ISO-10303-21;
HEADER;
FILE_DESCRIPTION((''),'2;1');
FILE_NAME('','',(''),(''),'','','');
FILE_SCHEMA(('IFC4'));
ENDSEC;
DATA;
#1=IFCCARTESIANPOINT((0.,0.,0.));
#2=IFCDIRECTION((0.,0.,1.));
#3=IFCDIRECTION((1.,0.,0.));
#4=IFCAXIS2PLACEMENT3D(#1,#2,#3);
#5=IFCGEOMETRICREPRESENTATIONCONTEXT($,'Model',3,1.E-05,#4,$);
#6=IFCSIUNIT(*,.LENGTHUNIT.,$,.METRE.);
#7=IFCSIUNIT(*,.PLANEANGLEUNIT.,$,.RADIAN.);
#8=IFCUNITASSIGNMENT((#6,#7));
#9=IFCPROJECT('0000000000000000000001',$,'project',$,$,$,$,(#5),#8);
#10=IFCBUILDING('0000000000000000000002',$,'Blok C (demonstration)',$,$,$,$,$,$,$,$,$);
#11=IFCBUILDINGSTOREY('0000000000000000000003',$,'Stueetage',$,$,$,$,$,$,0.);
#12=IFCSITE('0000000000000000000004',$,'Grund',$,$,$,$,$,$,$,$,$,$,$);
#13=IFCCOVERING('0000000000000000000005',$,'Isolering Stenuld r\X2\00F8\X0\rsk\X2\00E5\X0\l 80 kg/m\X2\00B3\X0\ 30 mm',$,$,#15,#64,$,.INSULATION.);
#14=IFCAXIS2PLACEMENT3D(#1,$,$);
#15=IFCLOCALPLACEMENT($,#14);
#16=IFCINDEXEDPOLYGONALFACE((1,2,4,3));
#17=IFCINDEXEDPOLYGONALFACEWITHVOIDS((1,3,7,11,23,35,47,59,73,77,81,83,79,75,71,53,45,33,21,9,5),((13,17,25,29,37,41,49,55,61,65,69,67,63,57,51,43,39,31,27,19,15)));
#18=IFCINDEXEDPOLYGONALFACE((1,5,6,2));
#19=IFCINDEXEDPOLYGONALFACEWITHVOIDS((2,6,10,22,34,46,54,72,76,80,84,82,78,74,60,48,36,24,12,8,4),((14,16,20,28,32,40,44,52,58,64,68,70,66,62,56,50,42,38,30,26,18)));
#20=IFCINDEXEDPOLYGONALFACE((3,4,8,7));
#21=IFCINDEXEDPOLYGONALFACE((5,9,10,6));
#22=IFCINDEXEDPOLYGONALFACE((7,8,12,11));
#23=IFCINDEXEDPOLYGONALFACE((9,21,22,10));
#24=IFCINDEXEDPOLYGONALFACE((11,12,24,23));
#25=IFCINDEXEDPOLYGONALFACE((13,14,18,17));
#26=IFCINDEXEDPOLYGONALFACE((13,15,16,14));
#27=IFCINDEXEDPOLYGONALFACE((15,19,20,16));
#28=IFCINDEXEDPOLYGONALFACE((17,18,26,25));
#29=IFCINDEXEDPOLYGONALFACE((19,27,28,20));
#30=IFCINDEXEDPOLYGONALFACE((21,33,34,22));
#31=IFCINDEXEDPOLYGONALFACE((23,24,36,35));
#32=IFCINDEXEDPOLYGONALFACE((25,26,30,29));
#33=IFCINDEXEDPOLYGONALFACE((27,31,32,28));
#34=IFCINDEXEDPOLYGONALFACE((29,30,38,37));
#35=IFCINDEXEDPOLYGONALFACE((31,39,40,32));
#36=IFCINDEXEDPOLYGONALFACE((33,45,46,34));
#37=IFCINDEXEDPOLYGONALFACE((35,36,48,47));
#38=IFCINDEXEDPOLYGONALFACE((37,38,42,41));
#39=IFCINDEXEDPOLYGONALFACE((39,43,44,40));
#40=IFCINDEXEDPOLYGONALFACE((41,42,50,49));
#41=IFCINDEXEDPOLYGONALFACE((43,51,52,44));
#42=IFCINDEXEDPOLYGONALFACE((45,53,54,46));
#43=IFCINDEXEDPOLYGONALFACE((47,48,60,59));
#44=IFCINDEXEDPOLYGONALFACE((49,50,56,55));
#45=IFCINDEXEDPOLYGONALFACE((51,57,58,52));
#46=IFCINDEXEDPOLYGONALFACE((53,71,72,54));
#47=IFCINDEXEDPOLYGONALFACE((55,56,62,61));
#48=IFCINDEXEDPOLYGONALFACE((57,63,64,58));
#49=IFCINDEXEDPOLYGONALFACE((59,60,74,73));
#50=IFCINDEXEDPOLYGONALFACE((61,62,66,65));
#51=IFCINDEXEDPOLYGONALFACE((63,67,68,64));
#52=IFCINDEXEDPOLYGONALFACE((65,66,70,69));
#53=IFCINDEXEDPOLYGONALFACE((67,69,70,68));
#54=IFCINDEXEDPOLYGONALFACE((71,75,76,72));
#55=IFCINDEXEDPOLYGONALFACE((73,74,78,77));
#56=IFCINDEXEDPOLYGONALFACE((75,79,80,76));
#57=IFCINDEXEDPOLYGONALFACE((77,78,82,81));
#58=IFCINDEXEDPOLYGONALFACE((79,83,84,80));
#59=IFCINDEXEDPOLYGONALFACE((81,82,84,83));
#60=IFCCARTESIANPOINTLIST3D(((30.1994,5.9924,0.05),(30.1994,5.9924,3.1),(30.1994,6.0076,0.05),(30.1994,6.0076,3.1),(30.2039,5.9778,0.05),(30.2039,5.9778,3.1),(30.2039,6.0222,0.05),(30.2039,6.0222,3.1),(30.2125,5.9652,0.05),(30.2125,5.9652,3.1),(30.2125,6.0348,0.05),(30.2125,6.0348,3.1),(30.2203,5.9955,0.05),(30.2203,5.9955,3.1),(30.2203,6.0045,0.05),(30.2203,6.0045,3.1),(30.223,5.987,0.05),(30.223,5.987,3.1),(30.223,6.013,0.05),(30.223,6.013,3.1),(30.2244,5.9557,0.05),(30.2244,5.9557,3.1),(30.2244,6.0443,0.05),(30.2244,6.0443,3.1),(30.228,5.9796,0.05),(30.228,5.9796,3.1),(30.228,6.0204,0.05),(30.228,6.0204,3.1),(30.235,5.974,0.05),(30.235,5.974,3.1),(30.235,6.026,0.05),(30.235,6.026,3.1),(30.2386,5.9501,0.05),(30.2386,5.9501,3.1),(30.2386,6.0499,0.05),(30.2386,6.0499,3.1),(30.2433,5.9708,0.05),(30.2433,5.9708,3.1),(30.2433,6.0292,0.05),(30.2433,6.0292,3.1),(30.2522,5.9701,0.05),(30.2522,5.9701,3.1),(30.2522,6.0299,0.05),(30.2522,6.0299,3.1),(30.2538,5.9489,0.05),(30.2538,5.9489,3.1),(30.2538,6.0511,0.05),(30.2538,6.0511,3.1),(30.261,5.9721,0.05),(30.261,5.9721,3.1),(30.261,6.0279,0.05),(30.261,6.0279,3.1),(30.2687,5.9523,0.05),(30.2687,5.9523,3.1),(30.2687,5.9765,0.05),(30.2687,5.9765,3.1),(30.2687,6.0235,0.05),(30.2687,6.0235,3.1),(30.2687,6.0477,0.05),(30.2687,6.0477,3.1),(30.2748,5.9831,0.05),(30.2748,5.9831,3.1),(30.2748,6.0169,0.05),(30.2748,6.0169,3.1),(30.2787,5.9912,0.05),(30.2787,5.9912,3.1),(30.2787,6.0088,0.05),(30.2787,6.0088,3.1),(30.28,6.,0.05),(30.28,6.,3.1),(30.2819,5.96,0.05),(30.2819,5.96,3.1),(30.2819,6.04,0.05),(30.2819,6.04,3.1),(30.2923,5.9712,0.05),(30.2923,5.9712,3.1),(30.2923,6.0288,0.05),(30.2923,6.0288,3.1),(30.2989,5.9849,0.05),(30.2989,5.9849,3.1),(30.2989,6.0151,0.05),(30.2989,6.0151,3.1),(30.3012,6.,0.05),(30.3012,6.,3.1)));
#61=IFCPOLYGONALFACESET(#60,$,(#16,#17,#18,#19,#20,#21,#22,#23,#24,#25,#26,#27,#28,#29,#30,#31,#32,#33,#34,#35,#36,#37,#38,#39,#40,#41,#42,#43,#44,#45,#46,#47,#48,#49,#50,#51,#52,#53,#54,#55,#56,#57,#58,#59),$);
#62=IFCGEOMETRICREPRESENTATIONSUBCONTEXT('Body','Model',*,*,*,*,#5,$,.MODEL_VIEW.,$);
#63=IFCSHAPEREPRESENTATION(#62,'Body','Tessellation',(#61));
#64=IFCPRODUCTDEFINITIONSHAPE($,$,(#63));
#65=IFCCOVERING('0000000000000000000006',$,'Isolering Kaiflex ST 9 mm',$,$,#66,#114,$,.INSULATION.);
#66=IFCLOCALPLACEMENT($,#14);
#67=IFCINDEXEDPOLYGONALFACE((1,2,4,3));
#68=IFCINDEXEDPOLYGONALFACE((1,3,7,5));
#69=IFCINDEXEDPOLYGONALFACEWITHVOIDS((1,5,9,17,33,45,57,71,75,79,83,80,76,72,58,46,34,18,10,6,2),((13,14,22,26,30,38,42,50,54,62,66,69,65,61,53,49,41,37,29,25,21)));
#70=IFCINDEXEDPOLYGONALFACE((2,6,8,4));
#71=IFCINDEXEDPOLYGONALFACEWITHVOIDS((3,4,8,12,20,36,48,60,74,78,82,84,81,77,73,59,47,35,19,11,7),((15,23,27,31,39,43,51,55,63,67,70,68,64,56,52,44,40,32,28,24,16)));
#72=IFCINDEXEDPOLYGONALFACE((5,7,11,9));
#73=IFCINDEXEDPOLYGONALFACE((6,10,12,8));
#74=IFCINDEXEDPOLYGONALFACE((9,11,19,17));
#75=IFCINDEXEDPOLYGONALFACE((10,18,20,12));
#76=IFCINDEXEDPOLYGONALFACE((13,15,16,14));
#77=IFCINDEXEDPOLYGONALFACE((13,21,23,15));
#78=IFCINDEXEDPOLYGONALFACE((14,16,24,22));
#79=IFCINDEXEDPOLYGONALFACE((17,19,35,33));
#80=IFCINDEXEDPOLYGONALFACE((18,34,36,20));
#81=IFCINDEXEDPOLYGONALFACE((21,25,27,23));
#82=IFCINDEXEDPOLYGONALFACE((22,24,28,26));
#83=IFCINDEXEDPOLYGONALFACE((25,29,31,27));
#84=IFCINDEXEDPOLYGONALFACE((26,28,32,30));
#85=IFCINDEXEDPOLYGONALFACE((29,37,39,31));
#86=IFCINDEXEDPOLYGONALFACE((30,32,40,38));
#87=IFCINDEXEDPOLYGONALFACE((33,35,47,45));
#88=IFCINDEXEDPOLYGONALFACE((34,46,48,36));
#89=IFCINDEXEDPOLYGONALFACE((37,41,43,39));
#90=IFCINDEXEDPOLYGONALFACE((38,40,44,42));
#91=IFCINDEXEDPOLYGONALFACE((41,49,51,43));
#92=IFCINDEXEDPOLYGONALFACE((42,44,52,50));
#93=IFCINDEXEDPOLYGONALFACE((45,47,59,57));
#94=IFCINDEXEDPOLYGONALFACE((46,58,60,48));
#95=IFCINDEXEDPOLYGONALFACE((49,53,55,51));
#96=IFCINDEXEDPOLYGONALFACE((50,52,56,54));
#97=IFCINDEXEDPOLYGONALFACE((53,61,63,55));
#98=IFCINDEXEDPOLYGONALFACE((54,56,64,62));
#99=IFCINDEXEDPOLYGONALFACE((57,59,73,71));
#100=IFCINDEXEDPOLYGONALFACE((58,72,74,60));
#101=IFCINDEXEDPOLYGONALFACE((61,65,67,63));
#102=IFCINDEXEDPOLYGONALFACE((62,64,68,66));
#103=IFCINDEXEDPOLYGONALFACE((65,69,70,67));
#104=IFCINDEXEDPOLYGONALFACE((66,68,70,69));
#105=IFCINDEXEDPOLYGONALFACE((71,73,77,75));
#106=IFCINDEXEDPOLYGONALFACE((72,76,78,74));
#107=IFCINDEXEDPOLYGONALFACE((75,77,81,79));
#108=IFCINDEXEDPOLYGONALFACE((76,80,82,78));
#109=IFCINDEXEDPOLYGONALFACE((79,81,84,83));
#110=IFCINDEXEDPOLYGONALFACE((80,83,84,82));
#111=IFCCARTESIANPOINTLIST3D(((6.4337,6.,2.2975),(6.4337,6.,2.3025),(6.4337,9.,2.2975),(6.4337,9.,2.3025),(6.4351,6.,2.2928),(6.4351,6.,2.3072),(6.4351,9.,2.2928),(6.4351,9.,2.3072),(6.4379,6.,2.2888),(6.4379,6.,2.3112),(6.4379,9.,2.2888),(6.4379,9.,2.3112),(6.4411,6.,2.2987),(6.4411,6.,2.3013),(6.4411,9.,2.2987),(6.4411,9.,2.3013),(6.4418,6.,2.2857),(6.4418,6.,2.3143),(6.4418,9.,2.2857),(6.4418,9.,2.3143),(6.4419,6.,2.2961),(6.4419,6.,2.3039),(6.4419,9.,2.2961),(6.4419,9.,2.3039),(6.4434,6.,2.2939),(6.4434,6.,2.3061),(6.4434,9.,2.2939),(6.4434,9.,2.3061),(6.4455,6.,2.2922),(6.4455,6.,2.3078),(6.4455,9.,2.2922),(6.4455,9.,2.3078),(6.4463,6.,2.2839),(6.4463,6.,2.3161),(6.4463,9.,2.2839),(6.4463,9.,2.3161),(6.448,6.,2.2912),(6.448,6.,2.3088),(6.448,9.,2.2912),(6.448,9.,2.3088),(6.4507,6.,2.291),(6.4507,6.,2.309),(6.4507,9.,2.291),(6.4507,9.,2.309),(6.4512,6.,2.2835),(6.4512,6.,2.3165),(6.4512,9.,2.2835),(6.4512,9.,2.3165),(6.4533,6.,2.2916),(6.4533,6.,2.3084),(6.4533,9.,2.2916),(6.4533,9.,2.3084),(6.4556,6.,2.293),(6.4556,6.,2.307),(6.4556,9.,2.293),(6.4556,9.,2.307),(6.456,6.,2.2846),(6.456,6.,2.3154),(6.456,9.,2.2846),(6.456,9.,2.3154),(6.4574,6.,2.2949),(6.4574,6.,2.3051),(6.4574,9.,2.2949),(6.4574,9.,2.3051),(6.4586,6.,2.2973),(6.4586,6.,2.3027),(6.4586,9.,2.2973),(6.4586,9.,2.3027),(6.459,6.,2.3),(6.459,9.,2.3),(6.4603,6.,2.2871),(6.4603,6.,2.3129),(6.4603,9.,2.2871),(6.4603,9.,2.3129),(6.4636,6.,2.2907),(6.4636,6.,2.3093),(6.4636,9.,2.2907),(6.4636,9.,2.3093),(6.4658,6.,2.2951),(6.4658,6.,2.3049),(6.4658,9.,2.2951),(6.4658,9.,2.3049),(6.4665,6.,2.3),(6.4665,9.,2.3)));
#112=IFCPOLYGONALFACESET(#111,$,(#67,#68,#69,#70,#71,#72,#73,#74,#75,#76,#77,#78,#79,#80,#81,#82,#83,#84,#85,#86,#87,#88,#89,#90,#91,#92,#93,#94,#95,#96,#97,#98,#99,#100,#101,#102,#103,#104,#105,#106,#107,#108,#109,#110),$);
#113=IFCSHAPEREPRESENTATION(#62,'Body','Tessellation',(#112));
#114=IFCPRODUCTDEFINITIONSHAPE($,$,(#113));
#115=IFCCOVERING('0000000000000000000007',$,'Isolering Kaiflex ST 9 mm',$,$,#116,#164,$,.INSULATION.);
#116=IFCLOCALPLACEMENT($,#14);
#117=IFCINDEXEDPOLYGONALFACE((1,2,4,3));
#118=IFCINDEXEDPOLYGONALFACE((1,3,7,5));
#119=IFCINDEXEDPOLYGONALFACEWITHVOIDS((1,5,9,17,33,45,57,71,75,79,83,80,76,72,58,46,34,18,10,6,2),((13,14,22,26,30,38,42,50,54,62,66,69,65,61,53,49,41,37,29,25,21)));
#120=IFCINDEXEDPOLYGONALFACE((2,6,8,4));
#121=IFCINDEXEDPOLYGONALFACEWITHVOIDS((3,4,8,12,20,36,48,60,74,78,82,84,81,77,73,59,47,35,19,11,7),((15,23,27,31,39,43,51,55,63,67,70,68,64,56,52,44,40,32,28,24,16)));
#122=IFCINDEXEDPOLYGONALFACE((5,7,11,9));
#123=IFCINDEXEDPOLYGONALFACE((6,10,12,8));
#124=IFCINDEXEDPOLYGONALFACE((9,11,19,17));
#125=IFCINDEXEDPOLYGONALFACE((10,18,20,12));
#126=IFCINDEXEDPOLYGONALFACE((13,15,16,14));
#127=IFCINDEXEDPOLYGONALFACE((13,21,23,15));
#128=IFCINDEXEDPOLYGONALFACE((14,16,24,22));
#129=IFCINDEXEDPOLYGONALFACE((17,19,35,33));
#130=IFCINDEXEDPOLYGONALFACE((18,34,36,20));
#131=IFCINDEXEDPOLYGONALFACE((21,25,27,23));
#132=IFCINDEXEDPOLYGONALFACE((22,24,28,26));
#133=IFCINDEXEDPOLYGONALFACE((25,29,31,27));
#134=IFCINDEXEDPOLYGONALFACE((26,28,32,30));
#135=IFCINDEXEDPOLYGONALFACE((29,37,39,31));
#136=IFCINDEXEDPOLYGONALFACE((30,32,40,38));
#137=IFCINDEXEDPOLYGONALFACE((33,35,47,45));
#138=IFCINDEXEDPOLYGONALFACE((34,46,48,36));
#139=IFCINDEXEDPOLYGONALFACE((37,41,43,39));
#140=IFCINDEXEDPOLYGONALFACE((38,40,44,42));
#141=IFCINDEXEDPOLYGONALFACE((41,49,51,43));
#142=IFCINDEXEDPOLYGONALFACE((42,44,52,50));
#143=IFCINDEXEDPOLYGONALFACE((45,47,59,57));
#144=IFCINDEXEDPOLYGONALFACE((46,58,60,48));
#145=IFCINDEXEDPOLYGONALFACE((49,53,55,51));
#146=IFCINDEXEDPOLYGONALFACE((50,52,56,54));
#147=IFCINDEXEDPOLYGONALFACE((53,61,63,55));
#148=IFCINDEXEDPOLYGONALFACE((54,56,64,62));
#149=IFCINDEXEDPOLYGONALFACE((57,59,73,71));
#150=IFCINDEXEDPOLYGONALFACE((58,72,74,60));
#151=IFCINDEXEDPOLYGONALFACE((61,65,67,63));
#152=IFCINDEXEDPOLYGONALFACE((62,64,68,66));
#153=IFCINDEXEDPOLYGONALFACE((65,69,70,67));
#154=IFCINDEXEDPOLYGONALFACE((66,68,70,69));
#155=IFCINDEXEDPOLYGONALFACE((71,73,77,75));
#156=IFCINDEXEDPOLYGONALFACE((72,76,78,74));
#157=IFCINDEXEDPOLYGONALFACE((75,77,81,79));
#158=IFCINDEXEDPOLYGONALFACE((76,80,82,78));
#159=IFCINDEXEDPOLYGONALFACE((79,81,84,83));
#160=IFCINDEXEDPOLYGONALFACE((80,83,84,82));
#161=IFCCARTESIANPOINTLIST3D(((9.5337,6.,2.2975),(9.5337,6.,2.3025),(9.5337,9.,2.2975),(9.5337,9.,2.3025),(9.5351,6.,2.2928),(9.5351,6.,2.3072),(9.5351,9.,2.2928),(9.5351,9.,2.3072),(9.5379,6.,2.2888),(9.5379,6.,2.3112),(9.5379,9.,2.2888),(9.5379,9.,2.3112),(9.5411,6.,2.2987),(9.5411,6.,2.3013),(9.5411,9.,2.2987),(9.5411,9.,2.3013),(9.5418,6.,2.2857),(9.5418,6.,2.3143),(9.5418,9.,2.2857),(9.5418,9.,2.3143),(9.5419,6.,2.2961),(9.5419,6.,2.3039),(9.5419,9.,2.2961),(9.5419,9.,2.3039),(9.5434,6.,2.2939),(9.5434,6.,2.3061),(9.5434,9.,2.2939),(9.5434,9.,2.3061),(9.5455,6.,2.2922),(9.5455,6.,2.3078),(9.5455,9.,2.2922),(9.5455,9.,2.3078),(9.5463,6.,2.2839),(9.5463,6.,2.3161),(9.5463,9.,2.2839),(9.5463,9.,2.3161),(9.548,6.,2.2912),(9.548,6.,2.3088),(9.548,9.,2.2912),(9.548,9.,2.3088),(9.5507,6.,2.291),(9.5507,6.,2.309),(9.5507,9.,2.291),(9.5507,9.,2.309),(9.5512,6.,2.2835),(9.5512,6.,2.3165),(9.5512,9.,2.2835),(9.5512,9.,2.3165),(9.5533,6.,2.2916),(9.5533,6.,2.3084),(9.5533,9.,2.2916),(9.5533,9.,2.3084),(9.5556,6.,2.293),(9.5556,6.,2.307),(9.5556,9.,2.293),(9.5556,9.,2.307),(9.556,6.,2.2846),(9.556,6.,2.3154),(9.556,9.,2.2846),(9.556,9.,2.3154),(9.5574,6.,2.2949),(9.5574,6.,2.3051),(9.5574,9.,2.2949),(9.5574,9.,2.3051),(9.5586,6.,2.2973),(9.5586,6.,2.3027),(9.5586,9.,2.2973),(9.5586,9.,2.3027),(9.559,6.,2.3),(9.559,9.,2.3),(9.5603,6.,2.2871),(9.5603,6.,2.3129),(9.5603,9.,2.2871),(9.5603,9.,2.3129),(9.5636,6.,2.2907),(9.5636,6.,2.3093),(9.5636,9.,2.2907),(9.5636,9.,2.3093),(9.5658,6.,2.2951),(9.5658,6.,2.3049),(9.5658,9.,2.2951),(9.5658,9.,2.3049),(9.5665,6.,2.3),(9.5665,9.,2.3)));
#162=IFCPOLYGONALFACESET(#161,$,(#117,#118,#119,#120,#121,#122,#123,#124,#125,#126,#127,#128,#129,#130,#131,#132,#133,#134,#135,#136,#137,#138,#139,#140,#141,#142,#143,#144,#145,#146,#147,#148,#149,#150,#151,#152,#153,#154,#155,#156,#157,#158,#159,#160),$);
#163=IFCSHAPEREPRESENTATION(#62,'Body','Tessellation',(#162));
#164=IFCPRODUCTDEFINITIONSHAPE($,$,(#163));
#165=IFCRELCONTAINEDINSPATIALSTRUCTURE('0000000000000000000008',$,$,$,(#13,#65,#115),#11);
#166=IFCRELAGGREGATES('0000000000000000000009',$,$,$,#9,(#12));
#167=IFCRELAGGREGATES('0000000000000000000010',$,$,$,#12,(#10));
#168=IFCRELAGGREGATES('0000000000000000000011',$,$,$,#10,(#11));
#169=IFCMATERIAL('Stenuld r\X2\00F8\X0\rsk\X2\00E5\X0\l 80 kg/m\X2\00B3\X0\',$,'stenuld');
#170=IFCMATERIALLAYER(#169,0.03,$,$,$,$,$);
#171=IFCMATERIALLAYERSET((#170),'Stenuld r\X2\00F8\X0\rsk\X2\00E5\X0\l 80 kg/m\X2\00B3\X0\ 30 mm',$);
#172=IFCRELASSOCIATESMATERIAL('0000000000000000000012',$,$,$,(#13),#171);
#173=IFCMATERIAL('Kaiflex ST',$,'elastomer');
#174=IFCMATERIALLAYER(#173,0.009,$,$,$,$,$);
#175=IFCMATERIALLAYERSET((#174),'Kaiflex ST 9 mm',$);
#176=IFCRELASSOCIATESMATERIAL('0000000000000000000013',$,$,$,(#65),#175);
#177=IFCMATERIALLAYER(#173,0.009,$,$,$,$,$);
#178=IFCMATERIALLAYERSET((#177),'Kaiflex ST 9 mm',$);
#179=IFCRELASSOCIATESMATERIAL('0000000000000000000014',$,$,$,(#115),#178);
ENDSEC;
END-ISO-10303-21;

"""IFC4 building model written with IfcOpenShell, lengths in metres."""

from ifc_helpers import new_model, si_unit, frame, origin_with_axes, place, context, subcontext, project, spatial, hollow_circle, extrude, material, layer, layer_set, element, save


model = new_model("IFC4")

# Units and contexts
model_context = context("Model", 3, precision=1e-05, world=origin_with_axes())
body_context = subcontext(model_context, "Body", "Model", "MODEL_VIEW")
ifc_project = project(units=[si_unit("LENGTHUNIT", "METRE"), si_unit("PLANEANGLEUNIT", "RADIAN")], contexts=[model_context])

# Site, building, storey
site = spatial("IfcSite", under=ifc_project, Name="Grund")
building = spatial("IfcBuilding", under=site, Name="Blok C (demonstration)")
storey = spatial("IfcBuildingStorey", under=building, Name="Stueetage", Elevation=0.0)

# Coverings
ifc_material_1 = material(Name="Stenuld rørskål 80 kg/m³", Category="stenuld")
ifc_material_2 = material(Name="Kaiflex ST", Category="elastomer")
ifc_layer_1 = layer(ifc_material_1, 0.03)
ifc_layer_set_1 = layer_set([ifc_layer_1], Name="Stenuld rørskål 80 kg/m³ 30 mm")
covering_1_placement = place(None, origin_with_axes())
element("IfcCovering", 1, at=covering_1_placement, inside=storey, material=ifc_layer_set_1, Name="Isolering Stenuld rørskål 80 kg/m³ 30 mm", PredefinedType="INSULATION", context=body_context, shape_type="SweptSolid", body=[
    extrude(hollow_circle(Radius=0.0512, WallThickness=0.0212), frame((30.25, 6.0, 0.05), z_axis=(0.0, 0.0, 1.0), x_axis=(1.0, 0.0, 0.0)), (0.0, 0.0, 1.0), 3.05),
])
ifc_layer_2 = layer(ifc_material_2, 0.009)
ifc_layer_set_2 = layer_set([ifc_layer_2], Name="Kaiflex ST 9 mm")
covering_2_placement = place(None, origin_with_axes())
element("IfcCovering", 2, at=covering_2_placement, inside=storey, material=ifc_layer_set_2, Name="Isolering Kaiflex ST 9 mm", PredefinedType="INSULATION", context=body_context, shape_type="SweptSolid", body=[
    extrude(hollow_circle(Radius=0.0165, WallThickness=0.0075), frame((6.45, 6.0, 2.3), z_axis=(0.0, 1.0, 0.0), x_axis=(1.0, 0.0, 0.0)), (0.0, 0.0, 1.0), 3.0),
])
ifc_layer_3 = layer(ifc_material_2, 0.009)
ifc_layer_set_3 = layer_set([ifc_layer_3], Name="Kaiflex ST 9 mm")
covering_3_placement = place(None, origin_with_axes())
element("IfcCovering", 3, at=covering_3_placement, inside=storey, material=ifc_layer_set_3, Name="Isolering Kaiflex ST 9 mm", PredefinedType="INSULATION", context=body_context, shape_type="SweptSolid", body=[
    extrude(hollow_circle(Radius=0.0165, WallThickness=0.0075), frame((9.55, 6.0, 2.3), z_axis=(0.0, 1.0, 0.0), x_axis=(1.0, 0.0, 0.0)), (0.0, 0.0, 1.0), 3.0),
])

save(model, "model.ifc")
